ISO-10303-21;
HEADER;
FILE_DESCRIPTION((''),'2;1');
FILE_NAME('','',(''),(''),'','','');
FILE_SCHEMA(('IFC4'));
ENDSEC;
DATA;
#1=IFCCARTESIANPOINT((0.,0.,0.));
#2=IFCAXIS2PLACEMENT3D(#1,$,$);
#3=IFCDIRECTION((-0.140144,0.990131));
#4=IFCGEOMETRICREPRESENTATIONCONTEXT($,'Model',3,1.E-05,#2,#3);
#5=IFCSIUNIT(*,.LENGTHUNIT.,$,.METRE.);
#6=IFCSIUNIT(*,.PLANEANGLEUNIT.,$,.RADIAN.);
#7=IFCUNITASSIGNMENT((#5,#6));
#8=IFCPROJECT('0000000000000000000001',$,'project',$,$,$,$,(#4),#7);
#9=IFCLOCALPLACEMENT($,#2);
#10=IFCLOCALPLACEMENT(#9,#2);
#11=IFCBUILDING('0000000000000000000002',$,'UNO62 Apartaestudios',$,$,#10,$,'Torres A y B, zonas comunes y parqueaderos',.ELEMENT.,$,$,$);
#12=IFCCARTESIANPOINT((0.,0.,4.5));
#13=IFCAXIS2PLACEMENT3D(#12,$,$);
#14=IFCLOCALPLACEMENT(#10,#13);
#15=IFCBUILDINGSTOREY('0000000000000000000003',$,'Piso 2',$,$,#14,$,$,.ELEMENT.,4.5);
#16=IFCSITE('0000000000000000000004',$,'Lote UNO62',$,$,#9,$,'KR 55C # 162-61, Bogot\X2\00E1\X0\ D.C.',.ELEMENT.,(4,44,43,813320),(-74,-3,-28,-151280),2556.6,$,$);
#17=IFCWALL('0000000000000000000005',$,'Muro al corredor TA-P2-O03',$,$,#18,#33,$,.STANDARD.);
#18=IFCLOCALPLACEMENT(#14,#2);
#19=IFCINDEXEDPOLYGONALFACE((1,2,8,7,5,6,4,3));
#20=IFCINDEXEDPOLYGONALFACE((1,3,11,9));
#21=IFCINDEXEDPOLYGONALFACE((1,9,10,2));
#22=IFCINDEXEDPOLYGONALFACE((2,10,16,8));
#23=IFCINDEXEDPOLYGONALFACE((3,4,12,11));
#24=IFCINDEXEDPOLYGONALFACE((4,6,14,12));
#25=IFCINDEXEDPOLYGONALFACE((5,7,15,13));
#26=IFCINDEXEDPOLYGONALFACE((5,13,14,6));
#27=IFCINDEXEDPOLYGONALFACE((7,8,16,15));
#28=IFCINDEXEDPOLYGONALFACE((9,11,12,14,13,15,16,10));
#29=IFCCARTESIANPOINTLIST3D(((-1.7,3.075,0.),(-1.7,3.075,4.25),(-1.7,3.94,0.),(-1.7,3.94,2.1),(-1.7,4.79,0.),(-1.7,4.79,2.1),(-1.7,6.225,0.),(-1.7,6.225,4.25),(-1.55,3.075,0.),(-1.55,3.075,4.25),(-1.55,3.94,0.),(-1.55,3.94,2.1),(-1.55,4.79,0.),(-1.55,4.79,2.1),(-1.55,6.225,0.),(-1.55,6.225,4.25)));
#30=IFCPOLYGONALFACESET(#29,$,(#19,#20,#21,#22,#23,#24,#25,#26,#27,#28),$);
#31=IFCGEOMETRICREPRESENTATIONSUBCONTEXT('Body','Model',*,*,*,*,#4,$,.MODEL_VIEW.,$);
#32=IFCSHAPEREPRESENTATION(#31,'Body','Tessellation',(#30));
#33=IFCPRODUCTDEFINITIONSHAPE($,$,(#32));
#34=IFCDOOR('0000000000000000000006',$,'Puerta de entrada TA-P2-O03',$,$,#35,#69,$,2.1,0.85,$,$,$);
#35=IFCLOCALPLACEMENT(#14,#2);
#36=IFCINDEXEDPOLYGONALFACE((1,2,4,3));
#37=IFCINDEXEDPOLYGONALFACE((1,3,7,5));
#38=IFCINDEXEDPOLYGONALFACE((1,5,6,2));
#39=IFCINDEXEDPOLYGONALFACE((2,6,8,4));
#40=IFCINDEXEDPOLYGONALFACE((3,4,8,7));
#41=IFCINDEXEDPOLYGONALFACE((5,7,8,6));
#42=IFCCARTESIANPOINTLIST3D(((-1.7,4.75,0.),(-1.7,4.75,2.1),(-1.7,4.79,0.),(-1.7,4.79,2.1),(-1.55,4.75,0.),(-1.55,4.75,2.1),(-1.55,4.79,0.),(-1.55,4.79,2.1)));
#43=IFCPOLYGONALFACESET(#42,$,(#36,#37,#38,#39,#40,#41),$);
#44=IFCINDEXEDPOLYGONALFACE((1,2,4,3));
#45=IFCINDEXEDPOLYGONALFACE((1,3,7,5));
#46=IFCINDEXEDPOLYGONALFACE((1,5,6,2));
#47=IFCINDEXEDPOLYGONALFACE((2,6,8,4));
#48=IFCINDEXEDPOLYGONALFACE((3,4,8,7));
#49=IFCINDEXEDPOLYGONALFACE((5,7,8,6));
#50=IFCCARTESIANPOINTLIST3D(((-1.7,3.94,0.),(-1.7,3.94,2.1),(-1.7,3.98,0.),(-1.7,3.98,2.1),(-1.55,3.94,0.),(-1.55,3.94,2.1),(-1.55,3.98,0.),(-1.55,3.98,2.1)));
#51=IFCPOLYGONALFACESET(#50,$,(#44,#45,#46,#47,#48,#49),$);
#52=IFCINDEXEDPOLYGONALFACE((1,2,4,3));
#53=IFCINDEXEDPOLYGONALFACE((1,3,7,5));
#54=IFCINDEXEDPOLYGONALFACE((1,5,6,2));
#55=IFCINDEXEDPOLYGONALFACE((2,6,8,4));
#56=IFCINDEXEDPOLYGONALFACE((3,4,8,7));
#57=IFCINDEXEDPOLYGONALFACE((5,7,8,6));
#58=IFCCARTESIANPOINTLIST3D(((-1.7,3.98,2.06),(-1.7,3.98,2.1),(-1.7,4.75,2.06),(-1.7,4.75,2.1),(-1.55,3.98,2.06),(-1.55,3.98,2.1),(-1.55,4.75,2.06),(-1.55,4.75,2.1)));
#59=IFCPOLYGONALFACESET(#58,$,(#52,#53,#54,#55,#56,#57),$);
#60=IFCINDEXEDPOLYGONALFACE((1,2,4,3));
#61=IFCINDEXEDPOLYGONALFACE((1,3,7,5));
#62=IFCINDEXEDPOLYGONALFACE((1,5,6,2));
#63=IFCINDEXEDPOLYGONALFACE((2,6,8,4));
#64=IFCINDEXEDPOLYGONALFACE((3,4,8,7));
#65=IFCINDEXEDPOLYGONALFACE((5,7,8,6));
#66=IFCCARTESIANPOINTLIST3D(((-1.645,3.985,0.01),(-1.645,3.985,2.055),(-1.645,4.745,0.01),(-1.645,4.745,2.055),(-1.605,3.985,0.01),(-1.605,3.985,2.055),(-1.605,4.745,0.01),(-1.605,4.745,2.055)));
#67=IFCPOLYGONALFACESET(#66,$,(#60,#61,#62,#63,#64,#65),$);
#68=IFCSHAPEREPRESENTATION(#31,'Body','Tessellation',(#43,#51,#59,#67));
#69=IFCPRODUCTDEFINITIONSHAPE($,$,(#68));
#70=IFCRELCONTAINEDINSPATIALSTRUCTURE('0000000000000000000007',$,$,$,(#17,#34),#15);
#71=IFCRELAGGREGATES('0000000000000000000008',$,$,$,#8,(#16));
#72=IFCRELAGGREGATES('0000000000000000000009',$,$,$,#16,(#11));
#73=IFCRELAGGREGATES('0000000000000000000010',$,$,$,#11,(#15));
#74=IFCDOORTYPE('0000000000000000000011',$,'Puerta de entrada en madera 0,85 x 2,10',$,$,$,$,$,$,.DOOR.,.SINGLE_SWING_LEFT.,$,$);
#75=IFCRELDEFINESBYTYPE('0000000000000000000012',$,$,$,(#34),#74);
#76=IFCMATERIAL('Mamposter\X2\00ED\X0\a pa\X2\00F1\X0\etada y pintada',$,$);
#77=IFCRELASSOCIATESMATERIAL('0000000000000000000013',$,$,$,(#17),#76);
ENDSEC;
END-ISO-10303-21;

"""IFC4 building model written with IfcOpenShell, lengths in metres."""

from ifc_helpers import new_model, si_unit, direction, frame, frame_2d, origin, place, context, subcontext, project, spatial, rectangle, extrude, source, transform, mapped, material, type_object, type_shapes, element, fill, save


model = new_model("IFC4")

# Units and contexts
model_context = context("Model", 3, precision=1e-05, world=origin(), true_north=direction((-0.140144, 0.990131)))
body_context = subcontext(model_context, "Body", "Model", "MODEL_VIEW")
ifc_project = project(units=[si_unit("LENGTHUNIT", "METRE"), si_unit("PLANEANGLEUNIT", "RADIAN")], contexts=[model_context])

# Site, building, storey
site_placement = place(None, origin())
site = spatial("IfcSite", under=ifc_project, at=site_placement, Name="Lote UNO62", LongName="KR 55C # 162-61, Bogotá D.C.", CompositionType="ELEMENT", RefLatitude=(4, 44, 43, 813320), RefLongitude=(-74, -3, -28, -151280), RefElevation=2556.6)
building_placement = place(site_placement, origin())
building = spatial("IfcBuilding", under=site, at=building_placement, Name="UNO62 Apartaestudios", LongName="Torres A y B, zonas comunes y parqueaderos", CompositionType="ELEMENT")
storey_placement = place(building_placement, frame((0.0, 0.0, 4.5)))
storey = spatial("IfcBuildingStorey", under=building, at=storey_placement, Name="Piso 2", CompositionType="ELEMENT", Elevation=4.5)

# Shared definitions
ifc_material_1 = material(Name="Mampostería pañetada y pintada")

# Shared definitions
placement_1 = place(storey_placement, frame((-1.7, 6.15, 0.0), z_axis=(0.0, 0.0, 1.0), x_axis=(-1.0, 0.0, 0.0)))

# Wall, opening, door
door_type_1 = type_object("IfcDoorType", Name="Puerta de entrada en madera 0,85 x 2,10", OperationType="SINGLE_SWING_LEFT", PredefinedType="DOOR")
shared_shape_1 = source(origin(), body_context, "Body", "SweptSolid", [
    extrude(rectangle(XDim=0.15, YDim=0.04, at=frame_2d((-0.075, 1.38))), origin(), (0.0, 0.0, 1.0), 2.1),
    extrude(rectangle(XDim=0.15, YDim=0.04, at=frame_2d((-0.075, 2.19))), origin(), (0.0, 0.0, 1.0), 2.1),
    extrude(rectangle(XDim=0.15, YDim=0.77, at=frame_2d((-0.075, 1.785))), frame((0.0, 0.0, 2.06)), (0.0, 0.0, 1.0), 0.04),
    extrude(rectangle(XDim=0.04, YDim=0.76, at=frame_2d((-0.075, 1.785))), frame((0.0, 0.0, 0.01)), (0.0, 0.0, 1.0), 2.045),
])
type_shapes(door_type_1, [shared_shape_1])
wall_1_placement = place(storey_placement, origin())
wall_1 = element("IfcWall", 1, at=wall_1_placement, inside=storey, material=ifc_material_1, Name="Muro al corredor TA-P2-O03", PredefinedType="STANDARD", context=body_context, shape_type="SweptSolid", body=[
    extrude(rectangle(XDim=0.15, YDim=3.15, at=frame_2d((-1.625, 4.65))), origin(), (0.0, 0.0, 1.0), 4.25),
])
opening_1_placement = place(wall_1_placement, origin())
opening_1 = element("IfcOpeningElement", 2, at=opening_1_placement, cuts=wall_1, PredefinedType="OPENING", context=body_context, shape_type="SweptSolid", body=[
    extrude(rectangle(XDim=0.25, YDim=0.85, at=frame_2d((-1.625, 4.365))), origin(), (0.0, 0.0, 1.0), 2.1),
])
door_1_placement = place(placement_1, origin())
door_1 = element("IfcDoor", 3, at=door_1_placement, inside=storey, type_object=door_type_1, Name="Puerta de entrada TA-P2-O03", OverallHeight=2.1, OverallWidth=0.85, context=body_context, shape_type="MappedRepresentation", body=[
    mapped(shared_shape_1, transform((0.0, 0.0, 0.0))),
])
fill(opening_1, door_1)

save(model, "model.ifc")
